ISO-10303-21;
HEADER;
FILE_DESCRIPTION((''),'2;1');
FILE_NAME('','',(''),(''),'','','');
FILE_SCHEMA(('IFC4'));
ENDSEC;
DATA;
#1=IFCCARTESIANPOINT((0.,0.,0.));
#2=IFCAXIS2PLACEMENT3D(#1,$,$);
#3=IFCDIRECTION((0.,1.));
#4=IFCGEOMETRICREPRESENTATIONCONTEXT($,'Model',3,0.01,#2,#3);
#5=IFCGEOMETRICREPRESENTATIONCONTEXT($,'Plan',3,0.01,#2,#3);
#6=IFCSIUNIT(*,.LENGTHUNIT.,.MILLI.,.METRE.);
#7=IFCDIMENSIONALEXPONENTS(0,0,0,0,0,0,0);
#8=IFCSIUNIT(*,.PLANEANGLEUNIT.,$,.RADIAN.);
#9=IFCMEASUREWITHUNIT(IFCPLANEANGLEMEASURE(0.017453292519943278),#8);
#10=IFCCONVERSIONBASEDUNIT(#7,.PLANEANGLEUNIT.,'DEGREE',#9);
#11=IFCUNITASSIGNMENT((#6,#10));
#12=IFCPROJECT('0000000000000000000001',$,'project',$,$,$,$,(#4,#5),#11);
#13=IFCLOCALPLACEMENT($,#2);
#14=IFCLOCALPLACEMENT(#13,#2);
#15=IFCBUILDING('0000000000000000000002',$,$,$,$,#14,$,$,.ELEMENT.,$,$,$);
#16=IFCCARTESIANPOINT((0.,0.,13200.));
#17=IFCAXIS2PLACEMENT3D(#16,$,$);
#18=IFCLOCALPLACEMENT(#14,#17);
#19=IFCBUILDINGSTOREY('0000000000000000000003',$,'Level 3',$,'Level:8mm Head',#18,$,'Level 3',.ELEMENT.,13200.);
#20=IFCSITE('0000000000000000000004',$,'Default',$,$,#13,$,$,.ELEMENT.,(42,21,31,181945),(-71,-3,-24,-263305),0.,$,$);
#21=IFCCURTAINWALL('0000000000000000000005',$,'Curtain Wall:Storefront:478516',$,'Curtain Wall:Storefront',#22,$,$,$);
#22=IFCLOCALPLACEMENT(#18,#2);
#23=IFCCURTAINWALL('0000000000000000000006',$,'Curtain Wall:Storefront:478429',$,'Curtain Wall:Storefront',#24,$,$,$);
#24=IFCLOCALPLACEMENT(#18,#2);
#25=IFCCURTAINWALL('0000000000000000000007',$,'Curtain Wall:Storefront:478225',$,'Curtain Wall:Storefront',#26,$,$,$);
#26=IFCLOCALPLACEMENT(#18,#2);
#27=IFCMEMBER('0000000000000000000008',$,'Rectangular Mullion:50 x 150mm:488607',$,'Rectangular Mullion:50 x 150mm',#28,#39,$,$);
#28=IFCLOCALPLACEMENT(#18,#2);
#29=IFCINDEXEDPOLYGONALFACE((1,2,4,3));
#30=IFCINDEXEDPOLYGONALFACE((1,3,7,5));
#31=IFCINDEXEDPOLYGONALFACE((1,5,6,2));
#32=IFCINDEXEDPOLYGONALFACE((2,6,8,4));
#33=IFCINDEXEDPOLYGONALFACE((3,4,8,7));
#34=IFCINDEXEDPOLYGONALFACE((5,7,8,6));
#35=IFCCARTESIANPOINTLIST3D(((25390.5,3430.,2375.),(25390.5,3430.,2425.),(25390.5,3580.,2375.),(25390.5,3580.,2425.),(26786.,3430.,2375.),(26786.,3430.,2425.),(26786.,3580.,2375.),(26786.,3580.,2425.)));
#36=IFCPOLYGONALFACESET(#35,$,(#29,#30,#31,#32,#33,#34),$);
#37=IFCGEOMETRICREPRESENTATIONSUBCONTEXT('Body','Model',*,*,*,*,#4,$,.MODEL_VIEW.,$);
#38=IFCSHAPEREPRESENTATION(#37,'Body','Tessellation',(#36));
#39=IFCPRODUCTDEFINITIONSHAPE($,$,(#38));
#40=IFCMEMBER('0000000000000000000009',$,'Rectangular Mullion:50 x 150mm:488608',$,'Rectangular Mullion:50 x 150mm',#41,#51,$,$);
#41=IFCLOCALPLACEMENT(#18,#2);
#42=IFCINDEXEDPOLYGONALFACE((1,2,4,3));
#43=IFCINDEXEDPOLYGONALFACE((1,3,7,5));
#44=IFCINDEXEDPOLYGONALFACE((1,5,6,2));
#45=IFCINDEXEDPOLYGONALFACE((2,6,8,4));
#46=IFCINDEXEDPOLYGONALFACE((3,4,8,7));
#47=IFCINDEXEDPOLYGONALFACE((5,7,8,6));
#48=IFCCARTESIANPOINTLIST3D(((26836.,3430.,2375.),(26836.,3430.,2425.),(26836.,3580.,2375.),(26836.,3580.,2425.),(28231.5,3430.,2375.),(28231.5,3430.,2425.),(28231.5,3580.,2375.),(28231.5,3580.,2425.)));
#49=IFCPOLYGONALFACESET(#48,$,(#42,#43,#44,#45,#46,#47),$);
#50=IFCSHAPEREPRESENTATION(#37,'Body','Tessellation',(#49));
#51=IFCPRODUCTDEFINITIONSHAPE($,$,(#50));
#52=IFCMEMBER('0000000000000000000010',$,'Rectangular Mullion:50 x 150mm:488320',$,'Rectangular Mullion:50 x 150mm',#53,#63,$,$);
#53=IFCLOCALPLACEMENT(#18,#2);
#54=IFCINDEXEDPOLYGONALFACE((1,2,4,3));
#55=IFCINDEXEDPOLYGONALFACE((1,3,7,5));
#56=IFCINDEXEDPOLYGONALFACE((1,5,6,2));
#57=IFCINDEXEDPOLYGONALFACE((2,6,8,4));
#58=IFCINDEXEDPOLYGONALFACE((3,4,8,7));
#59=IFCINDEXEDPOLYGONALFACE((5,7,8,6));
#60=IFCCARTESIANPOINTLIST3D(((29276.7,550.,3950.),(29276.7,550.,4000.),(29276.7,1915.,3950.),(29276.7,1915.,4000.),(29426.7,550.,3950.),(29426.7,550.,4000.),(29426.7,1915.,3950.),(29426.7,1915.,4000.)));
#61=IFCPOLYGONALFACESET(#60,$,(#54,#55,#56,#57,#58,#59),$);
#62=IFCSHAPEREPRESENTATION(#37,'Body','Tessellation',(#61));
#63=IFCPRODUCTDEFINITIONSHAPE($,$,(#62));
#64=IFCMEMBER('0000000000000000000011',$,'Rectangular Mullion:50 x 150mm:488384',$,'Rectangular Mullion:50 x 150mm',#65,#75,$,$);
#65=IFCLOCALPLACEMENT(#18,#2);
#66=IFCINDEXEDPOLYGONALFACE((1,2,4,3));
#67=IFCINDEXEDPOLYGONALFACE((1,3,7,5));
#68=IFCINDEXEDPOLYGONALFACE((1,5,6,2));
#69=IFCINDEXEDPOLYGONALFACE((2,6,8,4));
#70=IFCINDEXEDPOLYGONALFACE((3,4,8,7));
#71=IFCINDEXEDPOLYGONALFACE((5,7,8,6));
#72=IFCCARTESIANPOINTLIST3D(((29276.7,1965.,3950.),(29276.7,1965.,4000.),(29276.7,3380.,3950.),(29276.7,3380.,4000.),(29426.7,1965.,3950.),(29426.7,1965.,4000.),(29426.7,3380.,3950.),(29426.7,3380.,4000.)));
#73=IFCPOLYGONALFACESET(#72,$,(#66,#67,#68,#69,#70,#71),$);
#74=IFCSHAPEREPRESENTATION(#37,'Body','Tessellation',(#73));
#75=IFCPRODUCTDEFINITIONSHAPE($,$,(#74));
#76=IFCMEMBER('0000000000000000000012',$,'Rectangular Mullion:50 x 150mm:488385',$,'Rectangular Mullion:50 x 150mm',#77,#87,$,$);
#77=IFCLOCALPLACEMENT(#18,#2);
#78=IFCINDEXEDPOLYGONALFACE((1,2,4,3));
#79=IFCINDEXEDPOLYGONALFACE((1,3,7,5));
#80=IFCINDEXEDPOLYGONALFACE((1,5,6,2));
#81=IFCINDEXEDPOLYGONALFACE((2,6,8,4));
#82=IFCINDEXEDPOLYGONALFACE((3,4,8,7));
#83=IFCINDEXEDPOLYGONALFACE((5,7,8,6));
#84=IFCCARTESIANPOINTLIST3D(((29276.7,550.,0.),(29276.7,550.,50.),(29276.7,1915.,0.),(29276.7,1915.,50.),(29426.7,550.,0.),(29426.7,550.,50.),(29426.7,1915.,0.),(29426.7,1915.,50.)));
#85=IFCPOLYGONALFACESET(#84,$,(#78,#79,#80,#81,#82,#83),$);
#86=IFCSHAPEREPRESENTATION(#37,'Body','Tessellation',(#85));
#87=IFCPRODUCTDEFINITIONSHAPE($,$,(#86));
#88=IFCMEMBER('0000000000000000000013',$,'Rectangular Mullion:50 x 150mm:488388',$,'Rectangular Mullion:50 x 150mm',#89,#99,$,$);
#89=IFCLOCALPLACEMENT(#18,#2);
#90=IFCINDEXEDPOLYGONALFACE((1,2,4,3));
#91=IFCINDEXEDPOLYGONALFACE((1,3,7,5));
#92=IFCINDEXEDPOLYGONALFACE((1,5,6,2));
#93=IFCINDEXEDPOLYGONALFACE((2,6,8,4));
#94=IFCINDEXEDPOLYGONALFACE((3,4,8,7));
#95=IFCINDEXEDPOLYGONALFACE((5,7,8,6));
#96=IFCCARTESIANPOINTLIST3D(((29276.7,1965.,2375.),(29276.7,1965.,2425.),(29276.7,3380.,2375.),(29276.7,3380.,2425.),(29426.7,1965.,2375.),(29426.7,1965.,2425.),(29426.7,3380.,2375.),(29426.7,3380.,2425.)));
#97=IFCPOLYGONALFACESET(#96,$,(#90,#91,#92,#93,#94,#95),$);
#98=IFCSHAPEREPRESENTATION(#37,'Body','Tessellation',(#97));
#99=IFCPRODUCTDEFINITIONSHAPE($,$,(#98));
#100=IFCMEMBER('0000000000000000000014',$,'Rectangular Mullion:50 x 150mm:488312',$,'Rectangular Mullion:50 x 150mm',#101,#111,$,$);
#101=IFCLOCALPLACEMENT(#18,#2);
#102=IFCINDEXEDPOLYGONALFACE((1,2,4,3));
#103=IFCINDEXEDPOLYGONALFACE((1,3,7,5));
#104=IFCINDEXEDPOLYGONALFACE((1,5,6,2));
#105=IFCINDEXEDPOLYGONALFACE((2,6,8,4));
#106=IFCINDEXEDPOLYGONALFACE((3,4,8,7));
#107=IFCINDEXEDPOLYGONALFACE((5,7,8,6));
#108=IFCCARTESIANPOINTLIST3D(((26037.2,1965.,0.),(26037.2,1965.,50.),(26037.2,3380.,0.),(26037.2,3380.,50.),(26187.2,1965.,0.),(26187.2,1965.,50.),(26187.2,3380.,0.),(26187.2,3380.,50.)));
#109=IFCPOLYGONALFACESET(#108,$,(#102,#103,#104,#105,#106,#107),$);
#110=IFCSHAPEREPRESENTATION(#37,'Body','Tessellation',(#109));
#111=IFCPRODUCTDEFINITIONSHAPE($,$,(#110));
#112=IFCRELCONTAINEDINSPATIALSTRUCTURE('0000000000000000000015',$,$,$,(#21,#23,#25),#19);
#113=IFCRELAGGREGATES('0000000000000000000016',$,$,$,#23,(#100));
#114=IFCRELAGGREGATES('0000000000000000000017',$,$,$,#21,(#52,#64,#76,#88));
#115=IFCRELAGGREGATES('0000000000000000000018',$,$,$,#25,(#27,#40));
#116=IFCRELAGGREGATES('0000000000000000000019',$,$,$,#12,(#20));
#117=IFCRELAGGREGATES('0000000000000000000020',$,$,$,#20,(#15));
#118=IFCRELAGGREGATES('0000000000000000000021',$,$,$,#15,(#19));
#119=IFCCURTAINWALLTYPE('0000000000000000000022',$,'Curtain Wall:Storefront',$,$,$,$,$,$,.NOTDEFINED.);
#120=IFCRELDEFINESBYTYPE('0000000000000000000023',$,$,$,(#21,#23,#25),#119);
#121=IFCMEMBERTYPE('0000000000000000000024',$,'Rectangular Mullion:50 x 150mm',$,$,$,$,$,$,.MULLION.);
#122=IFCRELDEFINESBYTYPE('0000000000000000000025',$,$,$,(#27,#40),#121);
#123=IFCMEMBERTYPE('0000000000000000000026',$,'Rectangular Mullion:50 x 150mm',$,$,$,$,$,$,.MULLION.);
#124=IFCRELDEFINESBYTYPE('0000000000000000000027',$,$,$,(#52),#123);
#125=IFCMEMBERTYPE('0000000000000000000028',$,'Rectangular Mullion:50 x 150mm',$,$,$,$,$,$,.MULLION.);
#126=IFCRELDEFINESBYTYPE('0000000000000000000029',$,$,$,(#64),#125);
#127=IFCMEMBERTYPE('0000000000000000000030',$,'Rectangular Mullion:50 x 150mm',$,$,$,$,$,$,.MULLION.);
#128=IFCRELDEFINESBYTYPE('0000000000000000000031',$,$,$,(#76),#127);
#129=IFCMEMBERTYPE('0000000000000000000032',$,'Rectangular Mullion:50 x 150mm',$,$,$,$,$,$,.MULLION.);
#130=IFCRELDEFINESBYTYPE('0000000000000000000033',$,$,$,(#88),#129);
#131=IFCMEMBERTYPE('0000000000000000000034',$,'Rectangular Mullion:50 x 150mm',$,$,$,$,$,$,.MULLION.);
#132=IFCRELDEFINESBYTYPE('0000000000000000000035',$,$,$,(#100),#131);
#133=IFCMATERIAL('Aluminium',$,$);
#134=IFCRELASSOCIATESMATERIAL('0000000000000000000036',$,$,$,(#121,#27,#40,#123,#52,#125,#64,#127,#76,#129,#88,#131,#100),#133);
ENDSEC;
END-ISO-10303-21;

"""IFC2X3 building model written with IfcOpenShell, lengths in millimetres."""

from ifc_helpers import new_model, entity, si_unit, converted_unit, direction, frame, origin, origin_2d_with_axis, place, context, subcontext, project, spatial, rectangle, extrude, source, transform, mapped, material, type_object, type_shapes, element, aggregate, save


model = new_model("IFC2X3")

# Units and contexts
model_context = context("Model", 3, precision=0.01, world=origin(), true_north=direction((0.0, 1.0)))
plan_context = context("Plan", 3, precision=0.01, world=origin(), true_north=direction((0.0, 1.0)))
body_context = subcontext(model_context, "Body", "Model", "MODEL_VIEW")
ifc_project = project(units=[si_unit("LENGTHUNIT", "METRE", prefix="MILLI"), converted_unit("PLANEANGLEUNIT", "DEGREE", entity("IfcPlaneAngleMeasure", 0.017453292519943278), si_unit("PLANEANGLEUNIT", "RADIAN"), dimensions=[0, 0, 0, 0, 0, 0, 0])], contexts=[model_context, plan_context])

# Site, building, storey
site_placement = place(None, origin())
site = spatial("IfcSite", under=ifc_project, at=site_placement, Name="Default", CompositionType="ELEMENT", RefLatitude=(42, 21, 31, 181945), RefLongitude=(-71, -3, -24, -263305), RefElevation=0.0)
building_placement = place(site_placement, origin())
building = spatial("IfcBuilding", under=site, at=building_placement, CompositionType="ELEMENT")
storey_placement = place(building_placement, frame((0.0, 0.0, 13200.0)))
storey = spatial("IfcBuildingStorey", under=building, at=storey_placement, Name="Level 3", ObjectType="Level:8mm Head", LongName="Level 3", CompositionType="ELEMENT", Elevation=13200.0)

# Curtain walls
curtain_wall_type = type_object("IfcCurtainWallType", Name="Curtain Wall:Storefront", PredefinedType="NOTDEFINED")
curtain_wall_1_placement = place(storey_placement, frame((0.0, 0.0, -13200.0)))
curtain_wall_1 = element("IfcCurtainWall", 1, at=curtain_wall_1_placement, inside=storey, type_object=curtain_wall_type, Name="Curtain Wall:Storefront:478516", ObjectType="Curtain Wall:Storefront")
ifc_material_1 = material(Name="Aluminium")
curtain_wall_2_placement = place(storey_placement, frame((0.0, 0.0, -13200.0)))
curtain_wall_2 = element("IfcCurtainWall", 2, at=curtain_wall_2_placement, inside=storey, type_object=curtain_wall_type, Name="Curtain Wall:Storefront:478429", ObjectType="Curtain Wall:Storefront")

# Curtain wall
curtain_wall_3_placement = place(storey_placement, frame((0.0, 0.0, -13200.0)))
curtain_wall_3 = element("IfcCurtainWall", 3, at=curtain_wall_3_placement, inside=storey, type_object=curtain_wall_type, Name="Curtain Wall:Storefront:478225", ObjectType="Curtain Wall:Storefront")

# Members
member_type_1 = type_object("IfcMemberType", Name="Rectangular Mullion:50 x 150mm", PredefinedType="MULLION", material=ifc_material_1)
shared_shape_1 = source(origin(), body_context, "Body", "SweptSolid", [
    extrude(rectangle(XDim=50.0, YDim=150.0, at=origin_2d_with_axis()), frame((0.0, 0.0, -1395.5), z_axis=(0.0, 0.0, 1.0), x_axis=(-1.0, 0.0, 0.0)), (0.0, 0.0, 1.0), 1395.5),
])
type_shapes(member_type_1, [shared_shape_1])
member_1_placement = place(curtain_wall_3_placement, frame((26786.0, 3505.0, 15600.0), z_axis=(1.0, 0.0, 0.0), x_axis=(0.0, 0.0, 1.0)))
member_1 = element("IfcMember", 4, at=member_1_placement, type_object=member_type_1, material=ifc_material_1, Name="Rectangular Mullion:50 x 150mm:488607", ObjectType="Rectangular Mullion:50 x 150mm", context=body_context, shape_type="MappedRepresentation", body=[
    mapped(shared_shape_1, transform((0.0, 0.0, 0.0), scale=1.0)),
])
member_2_placement = place(curtain_wall_3_placement, frame((28231.5, 3505.0, 15600.0), z_axis=(1.0, 0.0, 0.0), x_axis=(0.0, 0.0, 1.0)))
member_2 = element("IfcMember", 5, at=member_2_placement, type_object=member_type_1, material=ifc_material_1, Name="Rectangular Mullion:50 x 150mm:488608", ObjectType="Rectangular Mullion:50 x 150mm", context=body_context, shape_type="MappedRepresentation", body=[
    mapped(shared_shape_1, transform((0.0, 0.0, 0.0), scale=1.0)),
])
member_type_2 = type_object("IfcMemberType", Name="Rectangular Mullion:50 x 150mm", PredefinedType="MULLION", material=ifc_material_1)
shared_shape_2 = source(origin(), body_context, "Body", "SweptSolid", [
    extrude(rectangle(XDim=50.0, YDim=150.0, at=origin_2d_with_axis()), frame((-25.0, 0.0, -1365.0), z_axis=(0.0, 0.0, 1.0), x_axis=(-1.0, 0.0, 0.0)), (0.0, 0.0, 1.0), 1365.0),
])
type_shapes(member_type_2, [shared_shape_2])
member_3_placement = place(curtain_wall_1_placement, frame((29351.7, 550.0, 17200.0), z_axis=(0.0, -1.0, 0.0), x_axis=(0.0, 0.0, 1.0)))
member_3 = element("IfcMember", 6, at=member_3_placement, type_object=member_type_2, material=ifc_material_1, Name="Rectangular Mullion:50 x 150mm:488320", ObjectType="Rectangular Mullion:50 x 150mm", context=body_context, shape_type="MappedRepresentation", body=[
    mapped(shared_shape_2, transform((0.0, 0.0, 0.0), scale=1.0)),
])
member_type_3 = type_object("IfcMemberType", Name="Rectangular Mullion:50 x 150mm", PredefinedType="MULLION", material=ifc_material_1)
shared_shape_3 = source(origin(), body_context, "Body", "SweptSolid", [
    extrude(rectangle(XDim=50.0, YDim=150.0, at=origin_2d_with_axis()), frame((-25.0, 0.0, -1415.0), z_axis=(0.0, 0.0, 1.0), x_axis=(-1.0, 0.0, 0.0)), (0.0, 0.0, 1.0), 1415.0),
])
type_shapes(member_type_3, [shared_shape_3])
member_4_placement = place(curtain_wall_1_placement, frame((29351.7, 1965.0, 17200.0), z_axis=(0.0, -1.0, 0.0), x_axis=(0.0, 0.0, 1.0)))
member_4 = element("IfcMember", 7, at=member_4_placement, type_object=member_type_3, material=ifc_material_1, Name="Rectangular Mullion:50 x 150mm:488384", ObjectType="Rectangular Mullion:50 x 150mm", context=body_context, shape_type="MappedRepresentation", body=[
    mapped(shared_shape_3, transform((0.0, 0.0, 0.0), scale=1.0)),
])
member_type_4 = type_object("IfcMemberType", Name="Rectangular Mullion:50 x 150mm", PredefinedType="MULLION", material=ifc_material_1)
shared_shape_4 = source(origin(), body_context, "Body", "SweptSolid", [
    extrude(rectangle(XDim=50.0, YDim=150.0, at=origin_2d_with_axis()), frame((-25.0, 0.0, -1365.0), z_axis=(0.0, 0.0, 1.0), x_axis=(-1.0, 0.0, 0.0)), (0.0, 0.0, 1.0), 1365.0),
])
type_shapes(member_type_4, [shared_shape_4])
member_5_placement = place(curtain_wall_1_placement, frame((29351.7, 1915.0, 13200.0), z_axis=(0.0, 1.0, 0.0), x_axis=(0.0, 0.0, -1.0)))
member_5 = element("IfcMember", 8, at=member_5_placement, type_object=member_type_4, material=ifc_material_1, Name="Rectangular Mullion:50 x 150mm:488385", ObjectType="Rectangular Mullion:50 x 150mm", context=body_context, shape_type="MappedRepresentation", body=[
    mapped(shared_shape_4, transform((0.0, 0.0, 0.0), scale=1.0)),
])
member_type_5 = type_object("IfcMemberType", Name="Rectangular Mullion:50 x 150mm", PredefinedType="MULLION", material=ifc_material_1)
shared_shape_5 = source(origin(), body_context, "Body", "SweptSolid", [
    extrude(rectangle(XDim=50.0, YDim=150.0, at=origin_2d_with_axis()), frame((0.0, 0.0, -1415.0), z_axis=(0.0, 0.0, 1.0), x_axis=(-1.0, 0.0, 0.0)), (0.0, 0.0, 1.0), 1415.0),
])
type_shapes(member_type_5, [shared_shape_5])
member_6_placement = place(curtain_wall_1_placement, frame((29351.7, 1965.0, 15600.0), z_axis=(0.0, -1.0, 0.0), x_axis=(0.0, 0.0, 1.0)))
member_6 = element("IfcMember", 9, at=member_6_placement, type_object=member_type_5, material=ifc_material_1, Name="Rectangular Mullion:50 x 150mm:488388", ObjectType="Rectangular Mullion:50 x 150mm", context=body_context, shape_type="MappedRepresentation", body=[
    mapped(shared_shape_5, transform((0.0, 0.0, 0.0), scale=1.0)),
])
member_type_6 = type_object("IfcMemberType", Name="Rectangular Mullion:50 x 150mm", PredefinedType="MULLION", material=ifc_material_1)
shared_shape_6 = source(origin(), body_context, "Body", "SweptSolid", [
    extrude(rectangle(XDim=50.0, YDim=150.0, at=origin_2d_with_axis()), frame((-25.0, 0.0, -1415.0), z_axis=(0.0, 0.0, 1.0), x_axis=(-1.0, 0.0, 0.0)), (0.0, 0.0, 1.0), 1415.0),
])
type_shapes(member_type_6, [shared_shape_6])
member_7_placement = place(curtain_wall_2_placement, frame((26112.2, 3380.0, 13200.0), z_axis=(0.0, 1.0, 0.0), x_axis=(0.0, 0.0, -1.0)))
member_7 = element("IfcMember", 10, at=member_7_placement, type_object=member_type_6, material=ifc_material_1, Name="Rectangular Mullion:50 x 150mm:488312", ObjectType="Rectangular Mullion:50 x 150mm", context=body_context, shape_type="MappedRepresentation", body=[
    mapped(shared_shape_6, transform((0.0, 0.0, 0.0), scale=1.0)),
])

aggregate(curtain_wall_2, [member_7])
aggregate(curtain_wall_1, [member_3, member_4, member_5, member_6])

aggregate(curtain_wall_3, [member_1, member_2])

save(model, "model.ifc")
